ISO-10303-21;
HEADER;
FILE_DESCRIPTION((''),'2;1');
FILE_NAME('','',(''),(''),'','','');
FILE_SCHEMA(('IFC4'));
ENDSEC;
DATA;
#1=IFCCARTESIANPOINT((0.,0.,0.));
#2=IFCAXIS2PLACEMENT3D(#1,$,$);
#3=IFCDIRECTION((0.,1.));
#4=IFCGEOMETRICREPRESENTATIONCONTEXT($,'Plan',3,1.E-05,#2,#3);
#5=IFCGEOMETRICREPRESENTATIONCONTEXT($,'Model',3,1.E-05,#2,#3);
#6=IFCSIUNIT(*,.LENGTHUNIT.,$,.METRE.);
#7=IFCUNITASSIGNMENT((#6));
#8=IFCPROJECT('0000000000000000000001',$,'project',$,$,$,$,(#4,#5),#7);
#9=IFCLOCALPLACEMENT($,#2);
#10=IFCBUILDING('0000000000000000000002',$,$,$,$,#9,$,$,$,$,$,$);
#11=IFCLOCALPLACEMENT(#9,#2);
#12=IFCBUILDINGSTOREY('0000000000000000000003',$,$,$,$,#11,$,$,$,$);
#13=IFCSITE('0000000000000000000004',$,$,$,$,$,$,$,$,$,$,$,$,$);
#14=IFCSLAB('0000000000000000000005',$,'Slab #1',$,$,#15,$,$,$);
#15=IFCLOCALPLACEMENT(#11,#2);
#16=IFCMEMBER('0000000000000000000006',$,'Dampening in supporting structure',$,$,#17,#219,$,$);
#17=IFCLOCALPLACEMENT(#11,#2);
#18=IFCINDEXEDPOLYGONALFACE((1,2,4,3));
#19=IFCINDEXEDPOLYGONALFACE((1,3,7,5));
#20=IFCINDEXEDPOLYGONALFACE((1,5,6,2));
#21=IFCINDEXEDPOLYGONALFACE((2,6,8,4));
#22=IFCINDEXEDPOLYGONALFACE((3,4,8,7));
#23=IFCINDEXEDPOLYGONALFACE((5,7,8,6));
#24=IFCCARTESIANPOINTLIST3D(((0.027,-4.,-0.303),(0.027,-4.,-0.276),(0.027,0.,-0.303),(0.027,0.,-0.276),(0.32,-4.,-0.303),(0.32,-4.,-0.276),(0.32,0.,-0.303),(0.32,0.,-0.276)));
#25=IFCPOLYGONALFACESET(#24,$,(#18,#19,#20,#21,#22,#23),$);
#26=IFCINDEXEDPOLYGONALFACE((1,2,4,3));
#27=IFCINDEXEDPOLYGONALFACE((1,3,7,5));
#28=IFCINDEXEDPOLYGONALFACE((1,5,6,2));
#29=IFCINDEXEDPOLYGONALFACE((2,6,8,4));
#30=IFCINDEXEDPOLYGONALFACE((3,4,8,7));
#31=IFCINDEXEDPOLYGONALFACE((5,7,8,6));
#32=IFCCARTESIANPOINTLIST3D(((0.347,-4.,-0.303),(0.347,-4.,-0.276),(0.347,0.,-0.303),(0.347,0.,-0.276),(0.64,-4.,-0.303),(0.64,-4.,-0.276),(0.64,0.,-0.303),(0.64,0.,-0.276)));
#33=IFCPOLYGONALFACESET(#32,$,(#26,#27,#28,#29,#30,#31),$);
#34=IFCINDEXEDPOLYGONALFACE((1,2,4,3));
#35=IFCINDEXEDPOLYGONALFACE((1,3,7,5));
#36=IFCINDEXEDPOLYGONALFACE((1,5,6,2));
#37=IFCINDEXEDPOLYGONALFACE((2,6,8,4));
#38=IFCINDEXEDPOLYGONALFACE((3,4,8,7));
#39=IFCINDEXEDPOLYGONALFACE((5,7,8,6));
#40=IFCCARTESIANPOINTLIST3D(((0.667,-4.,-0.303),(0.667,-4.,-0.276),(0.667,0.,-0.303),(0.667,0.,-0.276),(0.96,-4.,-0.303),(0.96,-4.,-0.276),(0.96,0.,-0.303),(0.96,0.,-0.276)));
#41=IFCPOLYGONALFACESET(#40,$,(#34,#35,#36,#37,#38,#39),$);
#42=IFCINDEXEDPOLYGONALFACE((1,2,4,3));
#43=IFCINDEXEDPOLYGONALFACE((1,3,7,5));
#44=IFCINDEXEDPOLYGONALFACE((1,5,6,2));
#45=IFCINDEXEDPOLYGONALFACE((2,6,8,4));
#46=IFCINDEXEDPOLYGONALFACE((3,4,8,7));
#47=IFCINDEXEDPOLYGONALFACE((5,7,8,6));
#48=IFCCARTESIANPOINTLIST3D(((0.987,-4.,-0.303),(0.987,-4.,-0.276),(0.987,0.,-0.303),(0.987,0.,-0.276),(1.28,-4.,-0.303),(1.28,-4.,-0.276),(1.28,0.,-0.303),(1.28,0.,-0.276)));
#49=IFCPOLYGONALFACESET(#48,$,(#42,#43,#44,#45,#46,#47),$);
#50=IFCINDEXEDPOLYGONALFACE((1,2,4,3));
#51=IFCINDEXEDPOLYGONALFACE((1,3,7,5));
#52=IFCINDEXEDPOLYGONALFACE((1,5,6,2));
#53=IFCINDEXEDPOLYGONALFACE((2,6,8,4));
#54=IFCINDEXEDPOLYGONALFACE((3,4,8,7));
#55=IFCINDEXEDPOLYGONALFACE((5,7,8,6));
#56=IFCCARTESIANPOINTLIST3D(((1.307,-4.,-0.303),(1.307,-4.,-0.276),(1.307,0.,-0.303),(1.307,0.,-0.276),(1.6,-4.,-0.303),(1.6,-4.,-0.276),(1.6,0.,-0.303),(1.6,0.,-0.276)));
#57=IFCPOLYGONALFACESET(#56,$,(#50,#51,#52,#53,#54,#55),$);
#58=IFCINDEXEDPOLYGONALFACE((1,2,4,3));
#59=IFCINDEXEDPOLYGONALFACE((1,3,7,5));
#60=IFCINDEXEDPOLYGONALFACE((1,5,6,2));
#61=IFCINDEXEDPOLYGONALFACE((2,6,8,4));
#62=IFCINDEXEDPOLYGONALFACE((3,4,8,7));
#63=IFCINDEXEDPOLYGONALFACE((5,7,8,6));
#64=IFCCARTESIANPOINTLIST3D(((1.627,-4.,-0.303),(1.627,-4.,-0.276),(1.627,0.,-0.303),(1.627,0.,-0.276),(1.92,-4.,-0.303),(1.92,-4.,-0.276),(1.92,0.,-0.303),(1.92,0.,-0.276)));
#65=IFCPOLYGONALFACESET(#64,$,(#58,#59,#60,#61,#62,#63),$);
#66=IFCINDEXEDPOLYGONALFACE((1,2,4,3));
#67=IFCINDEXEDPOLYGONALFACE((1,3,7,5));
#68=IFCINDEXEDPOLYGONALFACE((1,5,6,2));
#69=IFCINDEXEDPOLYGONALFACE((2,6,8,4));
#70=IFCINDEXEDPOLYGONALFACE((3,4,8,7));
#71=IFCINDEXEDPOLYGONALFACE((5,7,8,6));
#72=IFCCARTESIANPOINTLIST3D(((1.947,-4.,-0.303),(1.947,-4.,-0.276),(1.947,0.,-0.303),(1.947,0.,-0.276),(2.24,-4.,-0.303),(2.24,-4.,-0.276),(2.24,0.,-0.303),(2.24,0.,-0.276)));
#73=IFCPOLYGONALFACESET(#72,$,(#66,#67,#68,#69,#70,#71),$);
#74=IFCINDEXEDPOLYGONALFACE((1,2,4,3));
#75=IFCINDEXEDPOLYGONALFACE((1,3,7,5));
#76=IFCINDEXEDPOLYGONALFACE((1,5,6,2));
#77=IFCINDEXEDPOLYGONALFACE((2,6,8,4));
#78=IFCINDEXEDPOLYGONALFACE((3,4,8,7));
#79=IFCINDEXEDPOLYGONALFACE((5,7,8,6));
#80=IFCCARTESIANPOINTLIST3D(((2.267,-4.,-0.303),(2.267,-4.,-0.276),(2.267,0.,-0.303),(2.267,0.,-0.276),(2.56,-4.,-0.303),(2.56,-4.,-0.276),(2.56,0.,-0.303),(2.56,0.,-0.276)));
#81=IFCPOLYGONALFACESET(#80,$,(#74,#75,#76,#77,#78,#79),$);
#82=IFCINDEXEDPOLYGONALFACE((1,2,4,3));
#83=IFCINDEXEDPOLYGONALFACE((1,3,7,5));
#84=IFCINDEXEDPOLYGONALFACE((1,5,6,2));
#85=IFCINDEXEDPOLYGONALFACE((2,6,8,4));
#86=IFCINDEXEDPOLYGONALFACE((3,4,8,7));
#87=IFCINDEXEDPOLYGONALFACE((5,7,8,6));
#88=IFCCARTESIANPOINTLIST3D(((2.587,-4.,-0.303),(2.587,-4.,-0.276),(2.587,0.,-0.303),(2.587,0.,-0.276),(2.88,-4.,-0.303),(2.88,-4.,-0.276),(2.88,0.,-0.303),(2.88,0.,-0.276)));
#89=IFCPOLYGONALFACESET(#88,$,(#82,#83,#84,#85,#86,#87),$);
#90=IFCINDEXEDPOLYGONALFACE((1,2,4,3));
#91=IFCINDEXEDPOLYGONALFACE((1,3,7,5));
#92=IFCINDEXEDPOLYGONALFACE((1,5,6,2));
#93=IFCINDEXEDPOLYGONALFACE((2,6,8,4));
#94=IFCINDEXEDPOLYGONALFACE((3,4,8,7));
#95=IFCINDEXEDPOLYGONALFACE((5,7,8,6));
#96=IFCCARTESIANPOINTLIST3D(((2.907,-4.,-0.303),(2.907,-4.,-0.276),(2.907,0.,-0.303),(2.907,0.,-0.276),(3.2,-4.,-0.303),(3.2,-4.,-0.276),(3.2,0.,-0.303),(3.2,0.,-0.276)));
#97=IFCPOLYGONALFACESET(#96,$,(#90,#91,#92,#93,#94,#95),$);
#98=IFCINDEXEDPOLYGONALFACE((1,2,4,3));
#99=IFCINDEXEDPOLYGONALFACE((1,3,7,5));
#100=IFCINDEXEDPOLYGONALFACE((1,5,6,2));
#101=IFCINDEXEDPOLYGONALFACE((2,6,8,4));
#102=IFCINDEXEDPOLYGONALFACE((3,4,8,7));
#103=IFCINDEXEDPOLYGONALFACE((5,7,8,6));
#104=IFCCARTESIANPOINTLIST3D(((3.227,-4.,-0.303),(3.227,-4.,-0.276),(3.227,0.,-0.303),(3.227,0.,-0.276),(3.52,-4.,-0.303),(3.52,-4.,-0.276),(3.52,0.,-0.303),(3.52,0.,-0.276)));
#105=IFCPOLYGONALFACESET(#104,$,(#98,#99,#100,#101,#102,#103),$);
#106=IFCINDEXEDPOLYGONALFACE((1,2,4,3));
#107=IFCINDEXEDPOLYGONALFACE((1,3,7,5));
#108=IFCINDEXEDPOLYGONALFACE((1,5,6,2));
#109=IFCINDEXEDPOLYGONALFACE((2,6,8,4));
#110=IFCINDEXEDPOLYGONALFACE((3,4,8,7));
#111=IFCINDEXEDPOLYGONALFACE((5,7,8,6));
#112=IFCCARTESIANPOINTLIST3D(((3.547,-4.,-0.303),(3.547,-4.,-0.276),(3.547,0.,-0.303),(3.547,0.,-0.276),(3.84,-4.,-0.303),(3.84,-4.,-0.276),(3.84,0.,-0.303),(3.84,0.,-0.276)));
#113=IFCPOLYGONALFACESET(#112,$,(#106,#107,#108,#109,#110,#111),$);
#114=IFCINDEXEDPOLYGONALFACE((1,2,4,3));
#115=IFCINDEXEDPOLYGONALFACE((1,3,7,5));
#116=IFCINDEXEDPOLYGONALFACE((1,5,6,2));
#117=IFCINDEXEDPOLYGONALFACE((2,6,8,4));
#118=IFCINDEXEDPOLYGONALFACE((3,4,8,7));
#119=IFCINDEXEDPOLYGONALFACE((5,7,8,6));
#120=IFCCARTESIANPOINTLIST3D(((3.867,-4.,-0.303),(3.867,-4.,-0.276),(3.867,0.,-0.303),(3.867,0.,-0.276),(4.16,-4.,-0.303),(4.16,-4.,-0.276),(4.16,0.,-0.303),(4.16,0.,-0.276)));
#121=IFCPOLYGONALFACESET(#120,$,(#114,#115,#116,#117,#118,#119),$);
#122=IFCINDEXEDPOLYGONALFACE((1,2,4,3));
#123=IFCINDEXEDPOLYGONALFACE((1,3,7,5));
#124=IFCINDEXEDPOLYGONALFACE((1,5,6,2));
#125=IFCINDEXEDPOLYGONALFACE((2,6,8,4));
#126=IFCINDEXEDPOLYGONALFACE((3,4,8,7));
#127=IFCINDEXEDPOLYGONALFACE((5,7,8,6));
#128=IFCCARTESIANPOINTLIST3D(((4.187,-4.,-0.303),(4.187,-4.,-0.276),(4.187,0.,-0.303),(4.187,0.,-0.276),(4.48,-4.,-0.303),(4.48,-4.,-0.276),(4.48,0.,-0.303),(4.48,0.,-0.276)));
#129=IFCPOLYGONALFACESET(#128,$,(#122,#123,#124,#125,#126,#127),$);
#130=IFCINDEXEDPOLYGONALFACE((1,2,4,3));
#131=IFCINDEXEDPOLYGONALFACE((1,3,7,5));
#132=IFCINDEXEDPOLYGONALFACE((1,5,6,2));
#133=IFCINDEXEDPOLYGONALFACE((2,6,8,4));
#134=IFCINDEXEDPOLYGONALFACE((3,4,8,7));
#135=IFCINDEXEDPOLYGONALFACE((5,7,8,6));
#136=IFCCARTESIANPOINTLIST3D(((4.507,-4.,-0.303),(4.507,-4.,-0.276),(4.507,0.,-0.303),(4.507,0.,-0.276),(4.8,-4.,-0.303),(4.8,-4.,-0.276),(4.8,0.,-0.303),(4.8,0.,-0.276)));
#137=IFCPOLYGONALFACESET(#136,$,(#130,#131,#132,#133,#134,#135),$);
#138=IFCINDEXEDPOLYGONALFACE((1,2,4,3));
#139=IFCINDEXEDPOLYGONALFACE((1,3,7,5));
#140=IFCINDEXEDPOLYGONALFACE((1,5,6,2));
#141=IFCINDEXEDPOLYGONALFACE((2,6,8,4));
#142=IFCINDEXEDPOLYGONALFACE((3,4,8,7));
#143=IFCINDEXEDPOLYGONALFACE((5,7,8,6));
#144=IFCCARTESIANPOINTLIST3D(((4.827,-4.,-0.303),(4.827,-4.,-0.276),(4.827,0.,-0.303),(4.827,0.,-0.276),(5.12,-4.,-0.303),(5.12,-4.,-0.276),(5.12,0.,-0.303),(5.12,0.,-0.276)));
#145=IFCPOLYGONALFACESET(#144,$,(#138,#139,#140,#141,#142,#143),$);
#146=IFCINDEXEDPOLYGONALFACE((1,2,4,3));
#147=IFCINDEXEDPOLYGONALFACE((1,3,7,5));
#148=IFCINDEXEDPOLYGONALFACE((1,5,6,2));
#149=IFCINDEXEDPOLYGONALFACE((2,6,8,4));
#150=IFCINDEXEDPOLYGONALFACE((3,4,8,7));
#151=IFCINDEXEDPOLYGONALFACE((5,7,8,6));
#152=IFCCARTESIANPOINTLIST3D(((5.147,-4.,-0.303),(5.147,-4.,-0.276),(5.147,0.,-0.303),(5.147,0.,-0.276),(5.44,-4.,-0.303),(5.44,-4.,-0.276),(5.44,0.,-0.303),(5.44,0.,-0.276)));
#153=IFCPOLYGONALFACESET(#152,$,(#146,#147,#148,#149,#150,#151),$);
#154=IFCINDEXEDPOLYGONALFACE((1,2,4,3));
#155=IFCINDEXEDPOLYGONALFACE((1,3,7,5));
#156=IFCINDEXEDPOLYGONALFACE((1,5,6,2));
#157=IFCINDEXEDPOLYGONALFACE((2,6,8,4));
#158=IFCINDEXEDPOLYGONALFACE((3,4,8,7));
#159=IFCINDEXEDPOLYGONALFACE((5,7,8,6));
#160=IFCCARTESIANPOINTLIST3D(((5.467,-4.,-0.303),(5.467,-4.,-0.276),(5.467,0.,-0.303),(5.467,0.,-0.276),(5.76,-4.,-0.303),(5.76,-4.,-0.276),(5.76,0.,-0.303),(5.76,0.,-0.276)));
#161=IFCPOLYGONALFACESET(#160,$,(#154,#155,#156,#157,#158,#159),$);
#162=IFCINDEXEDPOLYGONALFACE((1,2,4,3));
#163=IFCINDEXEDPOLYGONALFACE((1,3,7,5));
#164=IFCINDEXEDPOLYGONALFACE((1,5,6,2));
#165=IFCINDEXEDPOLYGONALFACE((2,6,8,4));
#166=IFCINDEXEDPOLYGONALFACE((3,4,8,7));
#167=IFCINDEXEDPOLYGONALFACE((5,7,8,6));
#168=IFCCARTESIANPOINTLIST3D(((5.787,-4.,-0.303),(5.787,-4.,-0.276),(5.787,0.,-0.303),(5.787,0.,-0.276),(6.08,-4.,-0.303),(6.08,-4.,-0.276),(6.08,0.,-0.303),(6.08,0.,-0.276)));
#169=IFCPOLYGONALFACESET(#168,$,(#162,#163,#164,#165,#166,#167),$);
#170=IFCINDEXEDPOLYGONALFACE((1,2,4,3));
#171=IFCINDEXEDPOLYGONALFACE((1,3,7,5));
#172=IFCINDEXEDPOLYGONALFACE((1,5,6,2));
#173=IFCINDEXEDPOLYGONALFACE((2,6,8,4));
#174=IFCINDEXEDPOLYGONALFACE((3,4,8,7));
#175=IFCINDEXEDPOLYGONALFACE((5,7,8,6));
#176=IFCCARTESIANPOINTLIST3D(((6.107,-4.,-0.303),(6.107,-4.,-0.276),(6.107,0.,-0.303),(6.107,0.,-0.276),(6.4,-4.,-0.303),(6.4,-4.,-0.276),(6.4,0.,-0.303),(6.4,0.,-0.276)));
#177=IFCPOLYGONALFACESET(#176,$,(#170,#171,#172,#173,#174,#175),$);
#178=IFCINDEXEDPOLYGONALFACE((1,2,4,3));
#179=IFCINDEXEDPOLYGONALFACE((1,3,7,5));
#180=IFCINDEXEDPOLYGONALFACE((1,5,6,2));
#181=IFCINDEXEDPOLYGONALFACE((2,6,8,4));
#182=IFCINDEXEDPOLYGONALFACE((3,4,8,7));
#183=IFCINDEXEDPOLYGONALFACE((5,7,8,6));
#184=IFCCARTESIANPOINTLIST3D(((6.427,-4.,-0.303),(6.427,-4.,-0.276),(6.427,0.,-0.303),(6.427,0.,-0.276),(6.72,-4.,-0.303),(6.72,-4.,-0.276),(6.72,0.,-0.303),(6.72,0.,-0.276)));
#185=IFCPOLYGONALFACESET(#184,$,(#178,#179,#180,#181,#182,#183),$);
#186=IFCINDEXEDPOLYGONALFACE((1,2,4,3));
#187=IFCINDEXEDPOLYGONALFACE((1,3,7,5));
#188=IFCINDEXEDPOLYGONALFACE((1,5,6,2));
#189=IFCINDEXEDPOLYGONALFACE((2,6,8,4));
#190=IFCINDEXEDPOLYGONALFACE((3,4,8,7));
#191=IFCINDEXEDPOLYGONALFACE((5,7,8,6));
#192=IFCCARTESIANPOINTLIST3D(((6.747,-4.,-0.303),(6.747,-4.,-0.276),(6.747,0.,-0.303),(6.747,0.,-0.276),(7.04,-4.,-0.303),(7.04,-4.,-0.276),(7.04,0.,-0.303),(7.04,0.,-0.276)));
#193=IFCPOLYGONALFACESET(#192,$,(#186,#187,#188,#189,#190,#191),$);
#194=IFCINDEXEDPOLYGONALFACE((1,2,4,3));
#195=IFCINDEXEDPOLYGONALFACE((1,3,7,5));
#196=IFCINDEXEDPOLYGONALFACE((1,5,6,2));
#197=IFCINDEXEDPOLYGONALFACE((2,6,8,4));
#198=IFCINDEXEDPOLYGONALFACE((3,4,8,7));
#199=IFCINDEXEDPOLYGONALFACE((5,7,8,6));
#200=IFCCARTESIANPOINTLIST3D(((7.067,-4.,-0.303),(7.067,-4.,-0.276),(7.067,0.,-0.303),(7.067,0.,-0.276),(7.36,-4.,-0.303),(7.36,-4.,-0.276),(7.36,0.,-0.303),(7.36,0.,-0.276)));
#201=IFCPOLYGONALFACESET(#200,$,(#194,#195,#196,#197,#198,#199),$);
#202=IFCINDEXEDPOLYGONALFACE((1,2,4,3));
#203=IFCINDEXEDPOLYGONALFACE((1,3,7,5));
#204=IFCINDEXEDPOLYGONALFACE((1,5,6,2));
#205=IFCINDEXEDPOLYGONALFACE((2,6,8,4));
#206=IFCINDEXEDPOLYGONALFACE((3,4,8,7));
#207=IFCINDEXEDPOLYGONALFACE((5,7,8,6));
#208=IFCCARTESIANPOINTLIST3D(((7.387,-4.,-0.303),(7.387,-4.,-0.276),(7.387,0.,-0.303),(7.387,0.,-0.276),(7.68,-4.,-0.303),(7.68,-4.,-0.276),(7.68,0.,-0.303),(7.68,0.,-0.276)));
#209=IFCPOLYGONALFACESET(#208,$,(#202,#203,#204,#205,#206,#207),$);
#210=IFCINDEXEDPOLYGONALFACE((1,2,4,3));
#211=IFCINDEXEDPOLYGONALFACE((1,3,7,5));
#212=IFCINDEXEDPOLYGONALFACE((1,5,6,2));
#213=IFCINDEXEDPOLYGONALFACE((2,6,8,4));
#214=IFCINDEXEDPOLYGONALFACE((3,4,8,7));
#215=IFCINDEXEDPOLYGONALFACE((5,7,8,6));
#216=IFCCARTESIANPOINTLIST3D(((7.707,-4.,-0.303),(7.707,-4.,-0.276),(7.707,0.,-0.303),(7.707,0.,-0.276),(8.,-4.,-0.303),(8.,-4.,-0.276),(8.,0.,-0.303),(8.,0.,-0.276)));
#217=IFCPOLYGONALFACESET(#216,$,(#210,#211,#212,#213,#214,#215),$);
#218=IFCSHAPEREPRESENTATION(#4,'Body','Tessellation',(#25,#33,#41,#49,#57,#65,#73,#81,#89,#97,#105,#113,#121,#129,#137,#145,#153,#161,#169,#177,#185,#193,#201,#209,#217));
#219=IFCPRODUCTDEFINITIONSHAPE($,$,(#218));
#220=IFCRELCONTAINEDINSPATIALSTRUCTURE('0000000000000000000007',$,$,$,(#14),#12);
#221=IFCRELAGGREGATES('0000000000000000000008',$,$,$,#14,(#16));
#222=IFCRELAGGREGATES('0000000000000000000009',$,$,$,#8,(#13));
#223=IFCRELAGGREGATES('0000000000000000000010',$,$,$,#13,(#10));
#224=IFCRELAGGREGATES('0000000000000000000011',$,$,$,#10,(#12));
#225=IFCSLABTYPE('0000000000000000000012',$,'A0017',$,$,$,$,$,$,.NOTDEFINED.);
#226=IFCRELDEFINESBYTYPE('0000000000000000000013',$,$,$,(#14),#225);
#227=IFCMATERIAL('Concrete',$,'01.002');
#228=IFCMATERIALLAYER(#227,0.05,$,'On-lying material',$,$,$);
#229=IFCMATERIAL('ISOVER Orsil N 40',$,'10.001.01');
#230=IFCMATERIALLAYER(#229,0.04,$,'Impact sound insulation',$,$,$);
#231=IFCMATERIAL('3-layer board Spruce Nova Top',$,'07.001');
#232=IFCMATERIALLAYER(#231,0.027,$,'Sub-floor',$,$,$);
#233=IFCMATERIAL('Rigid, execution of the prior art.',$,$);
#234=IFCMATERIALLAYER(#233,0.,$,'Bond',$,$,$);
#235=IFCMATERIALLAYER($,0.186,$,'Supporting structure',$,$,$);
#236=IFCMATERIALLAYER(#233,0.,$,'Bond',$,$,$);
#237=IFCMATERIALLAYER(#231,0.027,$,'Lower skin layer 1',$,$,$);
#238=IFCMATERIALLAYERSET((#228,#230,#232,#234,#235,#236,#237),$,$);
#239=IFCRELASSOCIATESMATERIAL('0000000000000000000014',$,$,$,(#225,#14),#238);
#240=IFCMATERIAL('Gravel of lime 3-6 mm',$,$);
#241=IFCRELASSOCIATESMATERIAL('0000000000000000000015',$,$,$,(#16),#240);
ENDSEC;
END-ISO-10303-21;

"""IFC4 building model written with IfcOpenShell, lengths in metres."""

from ifc_helpers import new_model, si_unit, direction, frame, frame_2d, origin, place, context, project, spatial, rectangle, extrude, material, layer, layer_set, type_object, element, aggregate, save


model = new_model("IFC4")

# Units and contexts
plan_context = context("Plan", 3, precision=1e-05, world=origin(), true_north=direction((0.0, 1.0)))
model_context = context("Model", 3, precision=1e-05, world=origin(), true_north=direction((0.0, 1.0)))
ifc_project = project(units=[si_unit("LENGTHUNIT", "METRE")], contexts=[plan_context, model_context])

# Site, building, storey
site = spatial("IfcSite", under=ifc_project)
building_placement = place(None, origin())
building = spatial("IfcBuilding", under=site, at=building_placement)
storey_placement = place(building_placement, origin())
storey = spatial("IfcBuildingStorey", under=building, at=storey_placement)

# Slab, member
ifc_material_1 = material(Name="Concrete", Category="01.002")
ifc_layer_1 = layer(ifc_material_1, 0.05, Name="On-lying material")
ifc_material_2 = material(Name="ISOVER Orsil N 40", Category="10.001.01")
ifc_layer_2 = layer(ifc_material_2, 0.04, Name="Impact sound insulation")
ifc_material_3 = material(Name="3-layer board Spruce Nova Top", Category="07.001")
ifc_layer_3 = layer(ifc_material_3, 0.027, Name="Sub-floor")
ifc_material_4 = material(Name="Rigid, execution of the prior art.")
ifc_layer_4 = layer(ifc_material_4, 0.0, Name="Bond")
ifc_layer_5 = layer(None, 0.186, Name="Supporting structure")
ifc_layer_6 = layer(ifc_material_4, 0.0, Name="Bond")
ifc_layer_7 = layer(ifc_material_3, 0.027, Name="Lower skin layer 1")
ifc_layer_set = layer_set([ifc_layer_1, ifc_layer_2, ifc_layer_3, ifc_layer_4, ifc_layer_5, ifc_layer_6, ifc_layer_7])
slab_type = type_object("IfcSlabType", Name="A0017", PredefinedType="NOTDEFINED", material=ifc_layer_set)
slab_placement = place(None, frame((0.0, 0.0, 0.0), z_axis=(0.0, 0.0, -1.0), x_axis=(1.0, 0.0, 0.0)))
slab = element("IfcSlab", 1, at=slab_placement, inside=storey, type_object=slab_type, material=ifc_layer_set, Name="Slab #1")
ifc_material_5 = material(Name="Gravel of lime 3-6 mm")
member_1_placement = place(slab_placement, origin())
member_1 = element("IfcMember", 2, at=member_1_placement, material=ifc_material_5, Name="Dampening in supporting structure", context=plan_context, shape_type="SweptSolid", body=[
    extrude(rectangle(XDim=0.293, YDim=0.027, at=frame_2d((0.1465, 0.0135), x_axis=(1.0, 0.0))), frame((0.027, 4.0, 0.276), z_axis=(0.0, -1.0, 0.0), x_axis=(1.0, 0.0, 0.0)), (0.0, 0.0, 1.0), 4.0),
    extrude(rectangle(XDim=0.293, YDim=0.027, at=frame_2d((0.1465, 0.0135), x_axis=(1.0, 0.0))), frame((0.347, 4.0, 0.276), z_axis=(0.0, -1.0, 0.0), x_axis=(1.0, 0.0, 0.0)), (0.0, 0.0, 1.0), 4.0),
    extrude(rectangle(XDim=0.293, YDim=0.027, at=frame_2d((0.1465, 0.0135), x_axis=(1.0, 0.0))), frame((0.667, 4.0, 0.276), z_axis=(0.0, -1.0, 0.0), x_axis=(1.0, 0.0, 0.0)), (0.0, 0.0, 1.0), 4.0),
    extrude(rectangle(XDim=0.293, YDim=0.027, at=frame_2d((0.1465, 0.0135), x_axis=(1.0, 0.0))), frame((0.987, 4.0, 0.276), z_axis=(0.0, -1.0, 0.0), x_axis=(1.0, 0.0, 0.0)), (0.0, 0.0, 1.0), 4.0),
    extrude(rectangle(XDim=0.293, YDim=0.027, at=frame_2d((0.1465, 0.0135), x_axis=(1.0, 0.0))), frame((1.307, 4.0, 0.276), z_axis=(0.0, -1.0, 0.0), x_axis=(1.0, 0.0, 0.0)), (0.0, 0.0, 1.0), 4.0),
    extrude(rectangle(XDim=0.293, YDim=0.027, at=frame_2d((0.1465, 0.0135), x_axis=(1.0, 0.0))), frame((1.627, 4.0, 0.276), z_axis=(0.0, -1.0, 0.0), x_axis=(1.0, 0.0, 0.0)), (0.0, 0.0, 1.0), 4.0),
    extrude(rectangle(XDim=0.293, YDim=0.027, at=frame_2d((0.1465, 0.0135), x_axis=(1.0, 0.0))), frame((1.947, 4.0, 0.276), z_axis=(0.0, -1.0, 0.0), x_axis=(1.0, 0.0, 0.0)), (0.0, 0.0, 1.0), 4.0),
    extrude(rectangle(XDim=0.293, YDim=0.027, at=frame_2d((0.1465, 0.0135), x_axis=(1.0, 0.0))), frame((2.267, 4.0, 0.276), z_axis=(0.0, -1.0, 0.0), x_axis=(1.0, 0.0, 0.0)), (0.0, 0.0, 1.0), 4.0),
    extrude(rectangle(XDim=0.293, YDim=0.027, at=frame_2d((0.1465, 0.0135), x_axis=(1.0, 0.0))), frame((2.587, 4.0, 0.276), z_axis=(0.0, -1.0, 0.0), x_axis=(1.0, 0.0, 0.0)), (0.0, 0.0, 1.0), 4.0),
    extrude(rectangle(XDim=0.293, YDim=0.027, at=frame_2d((0.1465, 0.0135), x_axis=(1.0, 0.0))), frame((2.907, 4.0, 0.276), z_axis=(0.0, -1.0, 0.0), x_axis=(1.0, 0.0, 0.0)), (0.0, 0.0, 1.0), 4.0),
    extrude(rectangle(XDim=0.293, YDim=0.027, at=frame_2d((0.1465, 0.0135), x_axis=(1.0, 0.0))), frame((3.227, 4.0, 0.276), z_axis=(0.0, -1.0, 0.0), x_axis=(1.0, 0.0, 0.0)), (0.0, 0.0, 1.0), 4.0),
    extrude(rectangle(XDim=0.293, YDim=0.027, at=frame_2d((0.1465, 0.0135), x_axis=(1.0, 0.0))), frame((3.547, 4.0, 0.276), z_axis=(0.0, -1.0, 0.0), x_axis=(1.0, 0.0, 0.0)), (0.0, 0.0, 1.0), 4.0),
    extrude(rectangle(XDim=0.293, YDim=0.027, at=frame_2d((0.1465, 0.0135), x_axis=(1.0, 0.0))), frame((3.867, 4.0, 0.276), z_axis=(0.0, -1.0, 0.0), x_axis=(1.0, 0.0, 0.0)), (0.0, 0.0, 1.0), 4.0),
    extrude(rectangle(XDim=0.293, YDim=0.027, at=frame_2d((0.1465, 0.0135), x_axis=(1.0, 0.0))), frame((4.187, 4.0, 0.276), z_axis=(0.0, -1.0, 0.0), x_axis=(1.0, 0.0, 0.0)), (0.0, 0.0, 1.0), 4.0),
    extrude(rectangle(XDim=0.293, YDim=0.027, at=frame_2d((0.1465, 0.0135), x_axis=(1.0, 0.0))), frame((4.507, 4.0, 0.276), z_axis=(0.0, -1.0, 0.0), x_axis=(1.0, 0.0, 0.0)), (0.0, 0.0, 1.0), 4.0),
    extrude(rectangle(XDim=0.293, YDim=0.027, at=frame_2d((0.1465, 0.0135), x_axis=(1.0, 0.0))), frame((4.827, 4.0, 0.276), z_axis=(0.0, -1.0, 0.0), x_axis=(1.0, 0.0, 0.0)), (0.0, 0.0, 1.0), 4.0),
    extrude(rectangle(XDim=0.293, YDim=0.027, at=frame_2d((0.1465, 0.0135), x_axis=(1.0, 0.0))), frame((5.147, 4.0, 0.276), z_axis=(0.0, -1.0, 0.0), x_axis=(1.0, 0.0, 0.0)), (0.0, 0.0, 1.0), 4.0),
    extrude(rectangle(XDim=0.293, YDim=0.027, at=frame_2d((0.1465, 0.0135), x_axis=(1.0, 0.0))), frame((5.467, 4.0, 0.276), z_axis=(0.0, -1.0, 0.0), x_axis=(1.0, 0.0, 0.0)), (0.0, 0.0, 1.0), 4.0),
    extrude(rectangle(XDim=0.293, YDim=0.027, at=frame_2d((0.1465, 0.0135), x_axis=(1.0, 0.0))), frame((5.787, 4.0, 0.276), z_axis=(0.0, -1.0, 0.0), x_axis=(1.0, 0.0, 0.0)), (0.0, 0.0, 1.0), 4.0),
    extrude(rectangle(XDim=0.293, YDim=0.027, at=frame_2d((0.1465, 0.0135), x_axis=(1.0, 0.0))), frame((6.107, 4.0, 0.276), z_axis=(0.0, -1.0, 0.0), x_axis=(1.0, 0.0, 0.0)), (0.0, 0.0, 1.0), 4.0),
    extrude(rectangle(XDim=0.293, YDim=0.027, at=frame_2d((0.1465, 0.0135), x_axis=(1.0, 0.0))), frame((6.427, 4.0, 0.276), z_axis=(0.0, -1.0, 0.0), x_axis=(1.0, 0.0, 0.0)), (0.0, 0.0, 1.0), 4.0),
    extrude(rectangle(XDim=0.293, YDim=0.027, at=frame_2d((0.1465, 0.0135), x_axis=(1.0, 0.0))), frame((6.747, 4.0, 0.276), z_axis=(0.0, -1.0, 0.0), x_axis=(1.0, 0.0, 0.0)), (0.0, 0.0, 1.0), 4.0),
    extrude(rectangle(XDim=0.293, YDim=0.027, at=frame_2d((0.1465, 0.0135), x_axis=(1.0, 0.0))), frame((7.067, 4.0, 0.276), z_axis=(0.0, -1.0, 0.0), x_axis=(1.0, 0.0, 0.0)), (0.0, 0.0, 1.0), 4.0),
    extrude(rectangle(XDim=0.293, YDim=0.027, at=frame_2d((0.1465, 0.0135), x_axis=(1.0, 0.0))), frame((7.387, 4.0, 0.276), z_axis=(0.0, -1.0, 0.0), x_axis=(1.0, 0.0, 0.0)), (0.0, 0.0, 1.0), 4.0),
    extrude(rectangle(XDim=0.293, YDim=0.027, at=frame_2d((0.1465, 0.0135), x_axis=(1.0, 0.0))), frame((7.707, 4.0, 0.276), z_axis=(0.0, -1.0, 0.0), x_axis=(1.0, 0.0, 0.0)), (0.0, 0.0, 1.0), 4.0),
])
aggregate(slab, [member_1])

save(model, "model.ifc")
